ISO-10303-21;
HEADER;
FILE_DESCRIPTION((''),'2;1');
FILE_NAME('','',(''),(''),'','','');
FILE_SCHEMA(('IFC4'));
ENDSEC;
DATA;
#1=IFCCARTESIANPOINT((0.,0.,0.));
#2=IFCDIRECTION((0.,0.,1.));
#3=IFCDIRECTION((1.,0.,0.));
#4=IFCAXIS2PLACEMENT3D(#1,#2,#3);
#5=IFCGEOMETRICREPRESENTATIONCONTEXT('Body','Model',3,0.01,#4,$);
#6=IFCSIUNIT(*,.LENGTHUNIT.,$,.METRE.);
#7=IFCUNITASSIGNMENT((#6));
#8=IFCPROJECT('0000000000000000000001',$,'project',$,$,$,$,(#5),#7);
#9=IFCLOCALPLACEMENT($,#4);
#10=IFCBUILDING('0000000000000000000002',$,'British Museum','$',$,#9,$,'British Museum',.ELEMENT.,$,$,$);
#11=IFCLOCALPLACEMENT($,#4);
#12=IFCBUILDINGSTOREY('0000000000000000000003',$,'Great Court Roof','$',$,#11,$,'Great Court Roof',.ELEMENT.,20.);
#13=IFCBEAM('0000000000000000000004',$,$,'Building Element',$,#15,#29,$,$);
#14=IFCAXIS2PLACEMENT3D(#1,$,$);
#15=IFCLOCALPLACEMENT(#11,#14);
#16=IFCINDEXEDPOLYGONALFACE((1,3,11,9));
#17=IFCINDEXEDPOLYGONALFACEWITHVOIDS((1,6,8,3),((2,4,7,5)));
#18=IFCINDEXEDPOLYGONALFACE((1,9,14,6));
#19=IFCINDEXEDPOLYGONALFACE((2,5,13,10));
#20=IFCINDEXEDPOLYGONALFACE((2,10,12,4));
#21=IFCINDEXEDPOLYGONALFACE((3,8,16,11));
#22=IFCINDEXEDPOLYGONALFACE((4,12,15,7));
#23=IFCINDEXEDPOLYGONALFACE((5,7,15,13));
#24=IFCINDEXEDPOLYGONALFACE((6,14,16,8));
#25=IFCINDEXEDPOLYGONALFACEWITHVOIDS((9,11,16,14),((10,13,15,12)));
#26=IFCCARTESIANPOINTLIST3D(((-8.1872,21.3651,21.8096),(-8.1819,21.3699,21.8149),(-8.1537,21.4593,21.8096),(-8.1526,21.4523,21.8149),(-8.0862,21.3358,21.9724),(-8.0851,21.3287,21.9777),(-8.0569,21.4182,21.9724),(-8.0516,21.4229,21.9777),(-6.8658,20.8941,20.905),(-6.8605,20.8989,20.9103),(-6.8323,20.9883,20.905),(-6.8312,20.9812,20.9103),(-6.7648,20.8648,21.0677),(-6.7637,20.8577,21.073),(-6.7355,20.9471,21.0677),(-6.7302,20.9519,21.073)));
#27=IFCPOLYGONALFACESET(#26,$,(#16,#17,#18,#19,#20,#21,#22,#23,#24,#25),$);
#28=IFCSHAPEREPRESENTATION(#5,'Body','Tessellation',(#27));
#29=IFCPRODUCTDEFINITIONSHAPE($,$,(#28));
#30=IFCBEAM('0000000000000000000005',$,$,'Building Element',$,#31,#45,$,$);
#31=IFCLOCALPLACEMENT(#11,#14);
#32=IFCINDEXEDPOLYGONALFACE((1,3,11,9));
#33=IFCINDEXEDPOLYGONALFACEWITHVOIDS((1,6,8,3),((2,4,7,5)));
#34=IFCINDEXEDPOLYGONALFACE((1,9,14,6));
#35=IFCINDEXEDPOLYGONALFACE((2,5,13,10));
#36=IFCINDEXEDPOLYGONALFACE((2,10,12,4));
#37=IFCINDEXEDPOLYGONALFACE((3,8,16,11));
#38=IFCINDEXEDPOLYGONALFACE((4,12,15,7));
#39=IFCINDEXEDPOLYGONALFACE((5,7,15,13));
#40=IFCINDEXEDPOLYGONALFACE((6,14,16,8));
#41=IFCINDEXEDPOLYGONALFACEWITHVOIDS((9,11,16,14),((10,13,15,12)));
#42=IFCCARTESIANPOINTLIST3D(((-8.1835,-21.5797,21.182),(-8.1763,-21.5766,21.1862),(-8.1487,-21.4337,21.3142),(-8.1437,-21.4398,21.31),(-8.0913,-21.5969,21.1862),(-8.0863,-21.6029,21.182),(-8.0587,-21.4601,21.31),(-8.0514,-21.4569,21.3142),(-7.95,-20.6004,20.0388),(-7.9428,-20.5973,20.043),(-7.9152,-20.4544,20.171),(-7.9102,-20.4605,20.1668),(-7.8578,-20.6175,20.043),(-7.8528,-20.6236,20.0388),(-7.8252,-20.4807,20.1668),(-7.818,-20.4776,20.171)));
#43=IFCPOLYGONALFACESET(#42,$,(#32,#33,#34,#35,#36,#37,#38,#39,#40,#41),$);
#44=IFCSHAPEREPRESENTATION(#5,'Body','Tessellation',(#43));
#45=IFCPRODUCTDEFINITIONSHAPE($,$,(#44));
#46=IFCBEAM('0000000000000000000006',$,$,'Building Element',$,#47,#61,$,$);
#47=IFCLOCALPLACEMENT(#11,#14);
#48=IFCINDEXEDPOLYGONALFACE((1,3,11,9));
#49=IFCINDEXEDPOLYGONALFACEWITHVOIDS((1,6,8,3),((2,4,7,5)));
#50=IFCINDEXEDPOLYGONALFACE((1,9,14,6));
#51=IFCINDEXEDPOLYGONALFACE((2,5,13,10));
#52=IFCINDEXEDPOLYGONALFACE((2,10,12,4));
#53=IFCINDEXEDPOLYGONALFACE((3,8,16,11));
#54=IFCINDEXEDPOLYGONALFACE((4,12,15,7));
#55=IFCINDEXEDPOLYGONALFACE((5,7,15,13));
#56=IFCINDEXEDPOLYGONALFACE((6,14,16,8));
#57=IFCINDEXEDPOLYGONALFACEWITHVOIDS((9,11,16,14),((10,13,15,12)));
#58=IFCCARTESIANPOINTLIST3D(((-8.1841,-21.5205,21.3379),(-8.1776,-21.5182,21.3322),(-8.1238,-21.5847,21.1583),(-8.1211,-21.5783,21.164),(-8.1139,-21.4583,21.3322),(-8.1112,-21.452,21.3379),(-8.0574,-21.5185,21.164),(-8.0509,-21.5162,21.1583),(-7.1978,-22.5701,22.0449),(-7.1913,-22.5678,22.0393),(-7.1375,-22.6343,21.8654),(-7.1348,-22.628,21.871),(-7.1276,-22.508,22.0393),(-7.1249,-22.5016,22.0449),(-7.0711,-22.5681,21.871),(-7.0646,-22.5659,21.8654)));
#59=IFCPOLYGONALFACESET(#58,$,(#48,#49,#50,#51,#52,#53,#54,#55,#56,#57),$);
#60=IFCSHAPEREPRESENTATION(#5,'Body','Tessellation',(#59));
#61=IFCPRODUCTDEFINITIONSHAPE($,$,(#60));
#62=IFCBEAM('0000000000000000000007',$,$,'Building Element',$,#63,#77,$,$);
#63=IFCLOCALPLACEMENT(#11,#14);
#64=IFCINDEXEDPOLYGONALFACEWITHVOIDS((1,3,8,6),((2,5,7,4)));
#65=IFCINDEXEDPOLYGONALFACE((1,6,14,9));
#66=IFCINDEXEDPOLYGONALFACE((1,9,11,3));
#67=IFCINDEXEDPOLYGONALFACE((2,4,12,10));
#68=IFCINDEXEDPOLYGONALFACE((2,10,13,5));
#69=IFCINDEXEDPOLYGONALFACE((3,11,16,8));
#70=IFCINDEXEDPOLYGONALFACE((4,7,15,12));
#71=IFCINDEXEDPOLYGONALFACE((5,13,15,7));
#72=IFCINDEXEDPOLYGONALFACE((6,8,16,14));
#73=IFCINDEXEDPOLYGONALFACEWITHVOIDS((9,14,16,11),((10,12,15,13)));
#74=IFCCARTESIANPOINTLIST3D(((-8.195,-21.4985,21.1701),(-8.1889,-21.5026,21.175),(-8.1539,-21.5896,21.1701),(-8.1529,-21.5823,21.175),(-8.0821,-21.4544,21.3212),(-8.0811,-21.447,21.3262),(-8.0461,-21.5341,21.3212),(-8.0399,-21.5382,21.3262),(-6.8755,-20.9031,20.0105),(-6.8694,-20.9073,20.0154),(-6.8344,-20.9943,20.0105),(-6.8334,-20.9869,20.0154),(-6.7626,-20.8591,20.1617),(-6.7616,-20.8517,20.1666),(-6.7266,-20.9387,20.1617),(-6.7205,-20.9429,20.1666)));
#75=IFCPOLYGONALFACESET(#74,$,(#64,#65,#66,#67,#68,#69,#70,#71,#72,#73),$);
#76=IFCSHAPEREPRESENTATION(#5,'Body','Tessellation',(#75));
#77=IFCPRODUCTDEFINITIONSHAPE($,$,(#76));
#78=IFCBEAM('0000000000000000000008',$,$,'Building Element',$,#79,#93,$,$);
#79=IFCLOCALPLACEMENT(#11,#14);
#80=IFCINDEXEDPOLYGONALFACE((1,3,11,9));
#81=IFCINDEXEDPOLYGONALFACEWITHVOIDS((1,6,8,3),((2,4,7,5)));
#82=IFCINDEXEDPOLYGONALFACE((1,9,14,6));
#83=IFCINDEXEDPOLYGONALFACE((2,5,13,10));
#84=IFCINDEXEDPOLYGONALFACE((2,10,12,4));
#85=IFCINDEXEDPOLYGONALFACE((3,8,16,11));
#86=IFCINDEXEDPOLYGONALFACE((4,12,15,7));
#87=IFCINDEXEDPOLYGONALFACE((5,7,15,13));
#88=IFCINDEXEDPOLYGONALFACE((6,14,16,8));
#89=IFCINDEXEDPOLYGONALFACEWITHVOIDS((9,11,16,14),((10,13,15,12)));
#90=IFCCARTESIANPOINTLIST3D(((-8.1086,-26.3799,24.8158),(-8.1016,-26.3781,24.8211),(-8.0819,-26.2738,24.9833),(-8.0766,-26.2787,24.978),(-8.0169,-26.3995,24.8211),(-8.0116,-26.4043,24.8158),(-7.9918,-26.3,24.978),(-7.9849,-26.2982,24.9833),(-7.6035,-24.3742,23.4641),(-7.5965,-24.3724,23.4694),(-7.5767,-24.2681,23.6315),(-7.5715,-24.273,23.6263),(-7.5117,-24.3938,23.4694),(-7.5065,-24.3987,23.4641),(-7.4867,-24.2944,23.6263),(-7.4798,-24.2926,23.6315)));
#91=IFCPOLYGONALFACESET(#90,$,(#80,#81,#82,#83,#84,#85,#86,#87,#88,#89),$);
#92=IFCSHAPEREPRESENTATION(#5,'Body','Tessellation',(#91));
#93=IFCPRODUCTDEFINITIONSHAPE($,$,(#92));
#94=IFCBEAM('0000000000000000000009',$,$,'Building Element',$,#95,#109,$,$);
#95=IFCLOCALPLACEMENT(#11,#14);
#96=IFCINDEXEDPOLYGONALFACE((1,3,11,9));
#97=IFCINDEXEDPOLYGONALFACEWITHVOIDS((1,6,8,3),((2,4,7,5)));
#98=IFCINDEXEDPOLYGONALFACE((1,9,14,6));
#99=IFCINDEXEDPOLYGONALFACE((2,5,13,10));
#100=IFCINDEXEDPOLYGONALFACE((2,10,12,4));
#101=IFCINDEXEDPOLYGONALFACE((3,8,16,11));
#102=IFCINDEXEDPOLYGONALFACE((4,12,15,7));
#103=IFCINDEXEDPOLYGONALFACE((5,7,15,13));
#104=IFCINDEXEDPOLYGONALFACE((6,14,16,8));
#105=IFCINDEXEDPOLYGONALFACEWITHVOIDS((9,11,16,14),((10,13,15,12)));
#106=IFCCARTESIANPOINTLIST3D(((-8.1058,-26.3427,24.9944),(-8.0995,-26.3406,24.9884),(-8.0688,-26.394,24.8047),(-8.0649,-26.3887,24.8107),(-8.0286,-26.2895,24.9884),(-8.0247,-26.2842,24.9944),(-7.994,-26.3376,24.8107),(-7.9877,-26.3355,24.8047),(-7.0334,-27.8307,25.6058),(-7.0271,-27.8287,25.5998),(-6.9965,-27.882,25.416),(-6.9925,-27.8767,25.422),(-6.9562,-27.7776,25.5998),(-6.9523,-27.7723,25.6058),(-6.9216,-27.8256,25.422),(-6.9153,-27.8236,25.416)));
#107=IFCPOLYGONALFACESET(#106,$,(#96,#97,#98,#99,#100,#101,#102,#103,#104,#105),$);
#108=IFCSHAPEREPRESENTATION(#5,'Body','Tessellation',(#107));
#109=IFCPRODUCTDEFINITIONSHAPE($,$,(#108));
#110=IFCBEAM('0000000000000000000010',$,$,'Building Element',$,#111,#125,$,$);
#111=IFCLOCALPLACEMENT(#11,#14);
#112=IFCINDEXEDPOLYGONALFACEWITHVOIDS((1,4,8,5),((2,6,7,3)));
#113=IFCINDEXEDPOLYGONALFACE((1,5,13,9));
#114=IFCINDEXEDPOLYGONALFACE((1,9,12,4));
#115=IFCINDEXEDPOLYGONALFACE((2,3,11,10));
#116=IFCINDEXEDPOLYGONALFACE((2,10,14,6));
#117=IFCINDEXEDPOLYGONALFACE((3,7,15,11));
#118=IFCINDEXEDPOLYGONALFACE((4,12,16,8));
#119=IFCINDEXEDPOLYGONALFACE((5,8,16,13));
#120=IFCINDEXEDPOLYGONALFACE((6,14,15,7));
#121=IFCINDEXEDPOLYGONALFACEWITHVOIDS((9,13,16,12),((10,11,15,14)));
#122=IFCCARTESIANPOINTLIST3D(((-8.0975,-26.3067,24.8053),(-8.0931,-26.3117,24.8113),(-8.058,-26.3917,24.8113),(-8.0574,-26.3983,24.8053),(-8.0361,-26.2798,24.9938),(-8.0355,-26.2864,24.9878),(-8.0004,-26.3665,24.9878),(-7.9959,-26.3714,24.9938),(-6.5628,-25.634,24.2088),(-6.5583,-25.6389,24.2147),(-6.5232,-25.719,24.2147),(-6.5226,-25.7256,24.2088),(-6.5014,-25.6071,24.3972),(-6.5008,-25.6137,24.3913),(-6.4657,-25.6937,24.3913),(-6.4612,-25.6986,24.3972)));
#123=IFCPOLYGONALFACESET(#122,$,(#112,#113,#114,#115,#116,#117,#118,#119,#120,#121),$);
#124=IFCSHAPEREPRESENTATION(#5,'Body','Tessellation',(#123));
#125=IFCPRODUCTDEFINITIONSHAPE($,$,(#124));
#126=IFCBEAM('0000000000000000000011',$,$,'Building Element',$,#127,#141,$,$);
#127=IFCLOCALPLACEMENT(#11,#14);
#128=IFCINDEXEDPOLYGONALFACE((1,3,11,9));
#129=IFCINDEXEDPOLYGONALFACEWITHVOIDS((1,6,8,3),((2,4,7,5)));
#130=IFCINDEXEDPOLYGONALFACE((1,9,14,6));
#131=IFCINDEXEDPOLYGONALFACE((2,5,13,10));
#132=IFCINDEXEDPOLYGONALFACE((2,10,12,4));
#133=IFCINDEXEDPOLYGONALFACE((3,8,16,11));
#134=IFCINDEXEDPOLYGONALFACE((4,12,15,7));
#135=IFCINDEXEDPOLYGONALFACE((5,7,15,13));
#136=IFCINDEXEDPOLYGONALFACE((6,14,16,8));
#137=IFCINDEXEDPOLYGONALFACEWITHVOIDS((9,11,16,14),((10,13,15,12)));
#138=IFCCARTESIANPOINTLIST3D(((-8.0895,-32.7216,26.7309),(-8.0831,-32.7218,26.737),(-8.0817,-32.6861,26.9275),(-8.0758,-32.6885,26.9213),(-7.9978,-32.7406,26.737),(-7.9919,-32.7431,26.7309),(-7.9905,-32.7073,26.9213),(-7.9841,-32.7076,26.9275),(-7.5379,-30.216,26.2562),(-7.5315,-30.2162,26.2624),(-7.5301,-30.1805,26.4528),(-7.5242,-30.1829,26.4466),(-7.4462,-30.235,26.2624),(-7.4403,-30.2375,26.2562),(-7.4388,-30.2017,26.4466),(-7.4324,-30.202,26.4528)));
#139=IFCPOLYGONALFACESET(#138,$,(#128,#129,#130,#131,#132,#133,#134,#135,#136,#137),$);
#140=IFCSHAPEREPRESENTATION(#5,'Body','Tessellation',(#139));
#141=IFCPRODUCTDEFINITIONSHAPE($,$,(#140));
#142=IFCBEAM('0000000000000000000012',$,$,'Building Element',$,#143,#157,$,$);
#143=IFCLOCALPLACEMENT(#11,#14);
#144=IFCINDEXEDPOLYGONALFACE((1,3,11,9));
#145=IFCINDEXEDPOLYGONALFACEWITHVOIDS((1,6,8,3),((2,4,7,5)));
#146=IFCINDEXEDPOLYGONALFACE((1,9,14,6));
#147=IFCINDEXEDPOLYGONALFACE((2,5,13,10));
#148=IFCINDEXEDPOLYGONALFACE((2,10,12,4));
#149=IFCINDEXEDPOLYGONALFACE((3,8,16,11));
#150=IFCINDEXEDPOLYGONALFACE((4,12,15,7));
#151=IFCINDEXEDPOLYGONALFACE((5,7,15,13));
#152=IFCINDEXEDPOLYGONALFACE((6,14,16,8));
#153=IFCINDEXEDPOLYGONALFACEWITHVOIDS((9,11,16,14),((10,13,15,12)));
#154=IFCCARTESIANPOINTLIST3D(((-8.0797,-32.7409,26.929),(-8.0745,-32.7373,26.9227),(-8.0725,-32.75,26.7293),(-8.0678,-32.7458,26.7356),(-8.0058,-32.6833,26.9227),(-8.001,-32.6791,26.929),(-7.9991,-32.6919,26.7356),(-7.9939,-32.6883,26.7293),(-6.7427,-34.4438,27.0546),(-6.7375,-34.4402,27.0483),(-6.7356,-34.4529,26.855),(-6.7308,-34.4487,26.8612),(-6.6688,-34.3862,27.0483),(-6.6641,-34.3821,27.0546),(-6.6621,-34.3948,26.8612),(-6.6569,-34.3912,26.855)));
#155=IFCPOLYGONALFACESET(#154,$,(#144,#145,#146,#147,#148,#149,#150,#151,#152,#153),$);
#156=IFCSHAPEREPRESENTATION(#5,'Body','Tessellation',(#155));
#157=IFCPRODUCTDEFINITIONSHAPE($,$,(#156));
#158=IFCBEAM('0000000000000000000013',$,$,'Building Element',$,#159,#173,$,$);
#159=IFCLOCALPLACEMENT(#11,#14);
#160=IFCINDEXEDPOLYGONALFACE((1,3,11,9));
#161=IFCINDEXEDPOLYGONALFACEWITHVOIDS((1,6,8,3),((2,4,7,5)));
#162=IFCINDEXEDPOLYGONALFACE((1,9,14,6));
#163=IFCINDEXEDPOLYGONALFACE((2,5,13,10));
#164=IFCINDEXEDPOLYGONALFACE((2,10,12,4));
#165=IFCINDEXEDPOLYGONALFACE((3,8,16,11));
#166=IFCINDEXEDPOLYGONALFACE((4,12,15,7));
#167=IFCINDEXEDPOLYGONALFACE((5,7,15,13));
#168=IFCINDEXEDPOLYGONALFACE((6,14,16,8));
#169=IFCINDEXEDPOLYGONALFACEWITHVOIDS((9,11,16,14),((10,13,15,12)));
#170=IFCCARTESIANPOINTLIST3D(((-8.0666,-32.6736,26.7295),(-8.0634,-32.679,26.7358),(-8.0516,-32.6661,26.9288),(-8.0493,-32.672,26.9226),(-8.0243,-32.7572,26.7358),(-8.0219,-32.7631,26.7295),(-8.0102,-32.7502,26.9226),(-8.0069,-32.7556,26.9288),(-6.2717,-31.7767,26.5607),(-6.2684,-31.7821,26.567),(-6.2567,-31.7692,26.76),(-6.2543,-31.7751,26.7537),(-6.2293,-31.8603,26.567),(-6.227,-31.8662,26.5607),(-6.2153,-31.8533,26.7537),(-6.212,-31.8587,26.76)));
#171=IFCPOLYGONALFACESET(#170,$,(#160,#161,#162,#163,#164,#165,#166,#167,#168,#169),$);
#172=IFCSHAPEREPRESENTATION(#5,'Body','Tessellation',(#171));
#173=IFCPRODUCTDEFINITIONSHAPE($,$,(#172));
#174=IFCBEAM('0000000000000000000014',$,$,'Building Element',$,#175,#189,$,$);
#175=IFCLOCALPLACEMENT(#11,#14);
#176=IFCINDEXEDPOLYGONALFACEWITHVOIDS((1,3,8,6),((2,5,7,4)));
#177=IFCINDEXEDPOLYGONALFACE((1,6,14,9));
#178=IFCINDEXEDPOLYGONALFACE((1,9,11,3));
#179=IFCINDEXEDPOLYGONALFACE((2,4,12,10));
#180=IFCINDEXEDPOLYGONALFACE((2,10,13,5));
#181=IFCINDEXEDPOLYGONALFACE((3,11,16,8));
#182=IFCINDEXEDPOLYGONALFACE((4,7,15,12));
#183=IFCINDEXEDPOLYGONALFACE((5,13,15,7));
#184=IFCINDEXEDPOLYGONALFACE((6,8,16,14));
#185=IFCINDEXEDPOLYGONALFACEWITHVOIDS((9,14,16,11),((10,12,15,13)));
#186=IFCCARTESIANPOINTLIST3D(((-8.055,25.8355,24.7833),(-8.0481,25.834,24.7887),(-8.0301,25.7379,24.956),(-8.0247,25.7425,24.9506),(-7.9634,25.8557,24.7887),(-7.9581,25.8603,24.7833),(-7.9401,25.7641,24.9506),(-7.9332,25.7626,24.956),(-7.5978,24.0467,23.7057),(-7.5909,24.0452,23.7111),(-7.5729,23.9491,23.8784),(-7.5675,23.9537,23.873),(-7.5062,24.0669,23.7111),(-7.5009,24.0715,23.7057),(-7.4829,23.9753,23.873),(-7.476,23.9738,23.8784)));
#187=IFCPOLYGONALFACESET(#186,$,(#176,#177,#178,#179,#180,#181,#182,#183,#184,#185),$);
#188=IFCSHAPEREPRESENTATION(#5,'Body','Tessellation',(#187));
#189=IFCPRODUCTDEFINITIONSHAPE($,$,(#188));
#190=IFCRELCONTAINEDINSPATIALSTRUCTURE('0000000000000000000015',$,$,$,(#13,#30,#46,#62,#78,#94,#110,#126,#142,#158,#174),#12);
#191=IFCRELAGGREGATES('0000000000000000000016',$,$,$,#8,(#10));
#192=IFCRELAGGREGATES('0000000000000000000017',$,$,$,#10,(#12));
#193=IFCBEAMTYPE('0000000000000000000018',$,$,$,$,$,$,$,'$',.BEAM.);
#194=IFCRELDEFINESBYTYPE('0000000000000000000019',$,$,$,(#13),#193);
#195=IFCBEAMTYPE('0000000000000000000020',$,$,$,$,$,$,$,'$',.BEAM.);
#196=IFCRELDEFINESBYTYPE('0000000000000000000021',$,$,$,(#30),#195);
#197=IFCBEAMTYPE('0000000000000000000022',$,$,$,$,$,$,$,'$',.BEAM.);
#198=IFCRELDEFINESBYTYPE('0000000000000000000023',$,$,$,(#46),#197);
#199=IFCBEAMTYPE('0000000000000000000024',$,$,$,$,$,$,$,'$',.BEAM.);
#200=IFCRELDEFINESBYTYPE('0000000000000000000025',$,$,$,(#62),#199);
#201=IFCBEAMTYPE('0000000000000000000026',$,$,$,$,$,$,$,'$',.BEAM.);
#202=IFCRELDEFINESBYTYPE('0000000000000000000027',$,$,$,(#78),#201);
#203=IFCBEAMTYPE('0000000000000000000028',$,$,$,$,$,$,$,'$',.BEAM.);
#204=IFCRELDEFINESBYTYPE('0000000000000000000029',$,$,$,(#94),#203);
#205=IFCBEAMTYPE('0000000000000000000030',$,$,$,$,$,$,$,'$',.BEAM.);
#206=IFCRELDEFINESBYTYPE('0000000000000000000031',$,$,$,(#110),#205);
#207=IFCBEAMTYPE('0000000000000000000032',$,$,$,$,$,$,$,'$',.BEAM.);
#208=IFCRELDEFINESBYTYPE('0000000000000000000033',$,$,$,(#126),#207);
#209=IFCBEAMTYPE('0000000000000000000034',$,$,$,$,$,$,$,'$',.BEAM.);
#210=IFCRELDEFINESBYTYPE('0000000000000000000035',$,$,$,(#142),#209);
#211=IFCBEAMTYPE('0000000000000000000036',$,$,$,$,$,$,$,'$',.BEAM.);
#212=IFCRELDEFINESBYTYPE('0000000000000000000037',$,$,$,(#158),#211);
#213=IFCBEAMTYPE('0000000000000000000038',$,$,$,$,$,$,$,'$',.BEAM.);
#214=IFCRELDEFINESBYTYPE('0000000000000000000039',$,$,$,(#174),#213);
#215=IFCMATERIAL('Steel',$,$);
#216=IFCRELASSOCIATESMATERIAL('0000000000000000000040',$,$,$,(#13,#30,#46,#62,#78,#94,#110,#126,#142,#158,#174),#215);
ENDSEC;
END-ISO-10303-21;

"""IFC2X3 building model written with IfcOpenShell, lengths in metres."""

from ifc_helpers import new_model, si_unit, frame, origin_with_axes, origin_2d, place, context, project, spatial, hollow_rectangle, extrude, material, type_object, element, save


model = new_model("IFC2X3")

# Units and contexts
model_context = context("Model", 3, precision=0.01, world=origin_with_axes(), identifier="Body")
ifc_project = project(units=[si_unit("LENGTHUNIT", "METRE")], contexts=[model_context])

# Building, storey
building_placement = place(None, origin_with_axes())
building = spatial("IfcBuilding", under=ifc_project, at=building_placement, Name="British Museum", Description="$", LongName="British Museum", CompositionType="ELEMENT")
storey_placement = place(None, origin_with_axes())
storey = spatial("IfcBuildingStorey", under=building, at=storey_placement, Name="Great Court Roof", Description="$", LongName="Great Court Roof", CompositionType="ELEMENT", Elevation=20.0)

# Beams
ifc_material = material(Name="Steel")
beam_type_1 = type_object("IfcBeamType", ElementType="$", PredefinedType="BEAM")
beam_1_placement = place(None, origin_with_axes())
element("IfcBeam", 1, at=beam_1_placement, inside=storey, type_object=beam_type_1, material=ifc_material, Description="Building Element", context=model_context, shape_type="SweptSolid", body=[
    extrude(hollow_rectangle(XDim=0.1, YDim=0.2, WallThickness=0.0063, InnerFilletRadius=0.0, OuterFilletRadius=0.0, at=origin_2d()), frame((-8.1194, 21.394, 21.8936), z_axis=(0.791624, -0.282191, -0.54194), x_axis=(0.335775, 0.941942, 0.0)), (0.0, 0.0, 1.0), 1.6692),
])
beam_type_2 = type_object("IfcBeamType", ElementType="$", PredefinedType="BEAM")
beam_2_placement = place(None, origin_with_axes())
element("IfcBeam", 2, at=beam_2_placement, inside=storey, type_object=beam_type_2, material=ifc_material, Description="Building Element", context=model_context, shape_type="SweptSolid", body=[
    extrude(hollow_rectangle(XDim=0.1, YDim=0.2, WallThickness=0.0063, InnerFilletRadius=0.0, OuterFilletRadius=0.0, at=origin_2d()), frame((-8.1175, -21.5183, 21.2481), z_axis=(0.153274, 0.642886, -0.75047), x_axis=(-0.972736, 0.231916, 0.0)), (0.0, 0.0, 1.0), 1.5233),
])
beam_type_3 = type_object("IfcBeamType", ElementType="$", PredefinedType="BEAM")
beam_3_placement = place(None, origin_with_axes())
element("IfcBeam", 3, at=beam_3_placement, inside=storey, type_object=beam_type_3, material=ifc_material, Description="Building Element", context=model_context, shape_type="SweptSolid", body=[
    extrude(hollow_rectangle(XDim=0.1, YDim=0.2, WallThickness=0.0063, InnerFilletRadius=0.0, OuterFilletRadius=0.0, at=origin_2d()), frame((-8.1175, -21.5183, 21.2481), z_axis=(0.614701, -0.654188, 0.440659), x_axis=(0.728759, 0.68477, 0.0)), (0.0, 0.0, 1.0), 1.6045),
])
beam_type_4 = type_object("IfcBeamType", ElementType="$", PredefinedType="BEAM")
beam_4_placement = place(None, origin_with_axes())
element("IfcBeam", 4, at=beam_4_placement, inside=storey, type_object=beam_type_4, material=ifc_material, Description="Building Element", context=model_context, shape_type="SweptSolid", body=[
    extrude(hollow_rectangle(XDim=0.1, YDim=0.2, WallThickness=0.0063, InnerFilletRadius=0.0, OuterFilletRadius=0.0, at=origin_2d()), frame((-8.1175, -21.5183, 21.2481), z_axis=(0.711419, 0.320982, -0.625182), x_axis=(-0.411264, 0.911516, 0.0)), (0.0, 0.0, 1.0), 1.8547),
])
beam_type_5 = type_object("IfcBeamType", ElementType="$", PredefinedType="BEAM")
beam_5_placement = place(None, origin_with_axes())
element("IfcBeam", 5, at=beam_5_placement, inside=storey, type_object=beam_type_5, material=ifc_material, Description="Building Element", context=model_context, shape_type="SweptSolid", body=[
    extrude(hollow_rectangle(XDim=0.1, YDim=0.2, WallThickness=0.0063, InnerFilletRadius=0.0, OuterFilletRadius=0.0, at=origin_2d()), frame((-8.0467, -26.3391, 24.8996), z_axis=(0.204437, 0.811737, -0.547073), x_axis=(-0.969719, 0.244225, 0.0)), (0.0, 0.0, 1.0), 2.4708),
])
beam_type_6 = type_object("IfcBeamType", ElementType="$", PredefinedType="BEAM")
beam_6_placement = place(None, origin_with_axes())
element("IfcBeam", 6, at=beam_6_placement, inside=storey, type_object=beam_type_6, material=ifc_material, Description="Building Element", context=model_context, shape_type="SweptSolid", body=[
    extrude(hollow_rectangle(XDim=0.1, YDim=0.2, WallThickness=0.0063, InnerFilletRadius=0.0, OuterFilletRadius=0.0, at=origin_2d()), frame((-8.0467, -26.3391, 24.8996), z_axis=(0.554648, -0.769666, 0.316196), x_axis=(0.81129, 0.584643, 0.0)), (0.0, 0.0, 1.0), 1.9334),
])
beam_type_7 = type_object("IfcBeamType", ElementType="$", PredefinedType="BEAM")
beam_7_placement = place(None, origin_with_axes())
element("IfcBeam", 7, at=beam_7_placement, inside=storey, type_object=beam_type_7, material=ifc_material, Description="Building Element", context=model_context, shape_type="SweptSolid", body=[
    extrude(hollow_rectangle(XDim=0.1, YDim=0.2, WallThickness=0.0063, InnerFilletRadius=0.0, OuterFilletRadius=0.0, at=origin_2d()), frame((-8.0467, -26.3391, 24.8996), z_axis=(0.862825, 0.378226, -0.335377), x_axis=(-0.401477, 0.915869, 0.0)), (0.0, 0.0, 1.0), 1.7787),
])
beam_type_8 = type_object("IfcBeamType", ElementType="$", PredefinedType="BEAM")
beam_8_placement = place(None, origin_with_axes())
element("IfcBeam", 8, at=beam_8_placement, inside=storey, type_object=beam_type_8, material=ifc_material, Description="Building Element", context=model_context, shape_type="SweptSolid", body=[
    extrude(hollow_rectangle(XDim=0.1, YDim=0.2, WallThickness=0.0063, InnerFilletRadius=0.0, OuterFilletRadius=0.0, at=origin_2d()), frame((-8.0368, -32.7146, 26.8292), z_axis=(0.211419, 0.960313, -0.181935), x_axis=(-0.976612, 0.215007, 0.0)), (0.0, 0.0, 1.0), 2.6091),
])
beam_type_9 = type_object("IfcBeamType", ElementType="$", PredefinedType="BEAM")
beam_9_placement = place(None, origin_with_axes())
element("IfcBeam", 9, at=beam_9_placement, inside=storey, type_object=beam_type_9, material=ifc_material, Description="Building Element", context=model_context, shape_type="SweptSolid", body=[
    extrude(hollow_rectangle(XDim=0.1, YDim=0.2, WallThickness=0.0063, InnerFilletRadius=0.0, OuterFilletRadius=0.0, at=origin_2d()), frame((-8.0368, -32.7146, 26.8292), z_axis=(0.616492, -0.785228, 0.057919), x_axis=(0.786548, 0.617529, 0.0)), (0.0, 0.0, 1.0), 2.1687),
])
beam_type_10 = type_object("IfcBeamType", ElementType="$", PredefinedType="BEAM")
beam_10_placement = place(None, origin_with_axes())
element("IfcBeam", 10, at=beam_10_placement, inside=storey, type_object=beam_type_10, material=ifc_material, Description="Building Element", context=model_context, shape_type="SweptSolid", body=[
    extrude(hollow_rectangle(XDim=0.1, YDim=0.2, WallThickness=0.0063, InnerFilletRadius=0.0, OuterFilletRadius=0.0, at=origin_2d()), frame((-8.0368, -32.7146, 26.8292), z_axis=(0.8914, 0.445394, -0.083847), x_axis=(-0.446968, 0.89455, 0.0)), (0.0, 0.0, 1.0), 2.0136),
])
beam_type_11 = type_object("IfcBeamType", ElementType="$", PredefinedType="BEAM")
beam_11_placement = place(None, origin_with_axes())
element("IfcBeam", 11, at=beam_11_placement, inside=storey, type_object=beam_type_11, material=ifc_material, Description="Building Element", context=model_context, shape_type="SweptSolid", body=[
    extrude(hollow_rectangle(XDim=0.1, YDim=0.2, WallThickness=0.0063, InnerFilletRadius=0.0, OuterFilletRadius=0.0, at=origin_2d()), frame((-7.9941, 25.7991, 24.8696), z_axis=(0.213868, -0.836764, -0.504069), x_axis=(0.968855, 0.24763, 0.0)), (0.0, 0.0, 1.0), 2.1378),
])

save(model, "model.ifc")
